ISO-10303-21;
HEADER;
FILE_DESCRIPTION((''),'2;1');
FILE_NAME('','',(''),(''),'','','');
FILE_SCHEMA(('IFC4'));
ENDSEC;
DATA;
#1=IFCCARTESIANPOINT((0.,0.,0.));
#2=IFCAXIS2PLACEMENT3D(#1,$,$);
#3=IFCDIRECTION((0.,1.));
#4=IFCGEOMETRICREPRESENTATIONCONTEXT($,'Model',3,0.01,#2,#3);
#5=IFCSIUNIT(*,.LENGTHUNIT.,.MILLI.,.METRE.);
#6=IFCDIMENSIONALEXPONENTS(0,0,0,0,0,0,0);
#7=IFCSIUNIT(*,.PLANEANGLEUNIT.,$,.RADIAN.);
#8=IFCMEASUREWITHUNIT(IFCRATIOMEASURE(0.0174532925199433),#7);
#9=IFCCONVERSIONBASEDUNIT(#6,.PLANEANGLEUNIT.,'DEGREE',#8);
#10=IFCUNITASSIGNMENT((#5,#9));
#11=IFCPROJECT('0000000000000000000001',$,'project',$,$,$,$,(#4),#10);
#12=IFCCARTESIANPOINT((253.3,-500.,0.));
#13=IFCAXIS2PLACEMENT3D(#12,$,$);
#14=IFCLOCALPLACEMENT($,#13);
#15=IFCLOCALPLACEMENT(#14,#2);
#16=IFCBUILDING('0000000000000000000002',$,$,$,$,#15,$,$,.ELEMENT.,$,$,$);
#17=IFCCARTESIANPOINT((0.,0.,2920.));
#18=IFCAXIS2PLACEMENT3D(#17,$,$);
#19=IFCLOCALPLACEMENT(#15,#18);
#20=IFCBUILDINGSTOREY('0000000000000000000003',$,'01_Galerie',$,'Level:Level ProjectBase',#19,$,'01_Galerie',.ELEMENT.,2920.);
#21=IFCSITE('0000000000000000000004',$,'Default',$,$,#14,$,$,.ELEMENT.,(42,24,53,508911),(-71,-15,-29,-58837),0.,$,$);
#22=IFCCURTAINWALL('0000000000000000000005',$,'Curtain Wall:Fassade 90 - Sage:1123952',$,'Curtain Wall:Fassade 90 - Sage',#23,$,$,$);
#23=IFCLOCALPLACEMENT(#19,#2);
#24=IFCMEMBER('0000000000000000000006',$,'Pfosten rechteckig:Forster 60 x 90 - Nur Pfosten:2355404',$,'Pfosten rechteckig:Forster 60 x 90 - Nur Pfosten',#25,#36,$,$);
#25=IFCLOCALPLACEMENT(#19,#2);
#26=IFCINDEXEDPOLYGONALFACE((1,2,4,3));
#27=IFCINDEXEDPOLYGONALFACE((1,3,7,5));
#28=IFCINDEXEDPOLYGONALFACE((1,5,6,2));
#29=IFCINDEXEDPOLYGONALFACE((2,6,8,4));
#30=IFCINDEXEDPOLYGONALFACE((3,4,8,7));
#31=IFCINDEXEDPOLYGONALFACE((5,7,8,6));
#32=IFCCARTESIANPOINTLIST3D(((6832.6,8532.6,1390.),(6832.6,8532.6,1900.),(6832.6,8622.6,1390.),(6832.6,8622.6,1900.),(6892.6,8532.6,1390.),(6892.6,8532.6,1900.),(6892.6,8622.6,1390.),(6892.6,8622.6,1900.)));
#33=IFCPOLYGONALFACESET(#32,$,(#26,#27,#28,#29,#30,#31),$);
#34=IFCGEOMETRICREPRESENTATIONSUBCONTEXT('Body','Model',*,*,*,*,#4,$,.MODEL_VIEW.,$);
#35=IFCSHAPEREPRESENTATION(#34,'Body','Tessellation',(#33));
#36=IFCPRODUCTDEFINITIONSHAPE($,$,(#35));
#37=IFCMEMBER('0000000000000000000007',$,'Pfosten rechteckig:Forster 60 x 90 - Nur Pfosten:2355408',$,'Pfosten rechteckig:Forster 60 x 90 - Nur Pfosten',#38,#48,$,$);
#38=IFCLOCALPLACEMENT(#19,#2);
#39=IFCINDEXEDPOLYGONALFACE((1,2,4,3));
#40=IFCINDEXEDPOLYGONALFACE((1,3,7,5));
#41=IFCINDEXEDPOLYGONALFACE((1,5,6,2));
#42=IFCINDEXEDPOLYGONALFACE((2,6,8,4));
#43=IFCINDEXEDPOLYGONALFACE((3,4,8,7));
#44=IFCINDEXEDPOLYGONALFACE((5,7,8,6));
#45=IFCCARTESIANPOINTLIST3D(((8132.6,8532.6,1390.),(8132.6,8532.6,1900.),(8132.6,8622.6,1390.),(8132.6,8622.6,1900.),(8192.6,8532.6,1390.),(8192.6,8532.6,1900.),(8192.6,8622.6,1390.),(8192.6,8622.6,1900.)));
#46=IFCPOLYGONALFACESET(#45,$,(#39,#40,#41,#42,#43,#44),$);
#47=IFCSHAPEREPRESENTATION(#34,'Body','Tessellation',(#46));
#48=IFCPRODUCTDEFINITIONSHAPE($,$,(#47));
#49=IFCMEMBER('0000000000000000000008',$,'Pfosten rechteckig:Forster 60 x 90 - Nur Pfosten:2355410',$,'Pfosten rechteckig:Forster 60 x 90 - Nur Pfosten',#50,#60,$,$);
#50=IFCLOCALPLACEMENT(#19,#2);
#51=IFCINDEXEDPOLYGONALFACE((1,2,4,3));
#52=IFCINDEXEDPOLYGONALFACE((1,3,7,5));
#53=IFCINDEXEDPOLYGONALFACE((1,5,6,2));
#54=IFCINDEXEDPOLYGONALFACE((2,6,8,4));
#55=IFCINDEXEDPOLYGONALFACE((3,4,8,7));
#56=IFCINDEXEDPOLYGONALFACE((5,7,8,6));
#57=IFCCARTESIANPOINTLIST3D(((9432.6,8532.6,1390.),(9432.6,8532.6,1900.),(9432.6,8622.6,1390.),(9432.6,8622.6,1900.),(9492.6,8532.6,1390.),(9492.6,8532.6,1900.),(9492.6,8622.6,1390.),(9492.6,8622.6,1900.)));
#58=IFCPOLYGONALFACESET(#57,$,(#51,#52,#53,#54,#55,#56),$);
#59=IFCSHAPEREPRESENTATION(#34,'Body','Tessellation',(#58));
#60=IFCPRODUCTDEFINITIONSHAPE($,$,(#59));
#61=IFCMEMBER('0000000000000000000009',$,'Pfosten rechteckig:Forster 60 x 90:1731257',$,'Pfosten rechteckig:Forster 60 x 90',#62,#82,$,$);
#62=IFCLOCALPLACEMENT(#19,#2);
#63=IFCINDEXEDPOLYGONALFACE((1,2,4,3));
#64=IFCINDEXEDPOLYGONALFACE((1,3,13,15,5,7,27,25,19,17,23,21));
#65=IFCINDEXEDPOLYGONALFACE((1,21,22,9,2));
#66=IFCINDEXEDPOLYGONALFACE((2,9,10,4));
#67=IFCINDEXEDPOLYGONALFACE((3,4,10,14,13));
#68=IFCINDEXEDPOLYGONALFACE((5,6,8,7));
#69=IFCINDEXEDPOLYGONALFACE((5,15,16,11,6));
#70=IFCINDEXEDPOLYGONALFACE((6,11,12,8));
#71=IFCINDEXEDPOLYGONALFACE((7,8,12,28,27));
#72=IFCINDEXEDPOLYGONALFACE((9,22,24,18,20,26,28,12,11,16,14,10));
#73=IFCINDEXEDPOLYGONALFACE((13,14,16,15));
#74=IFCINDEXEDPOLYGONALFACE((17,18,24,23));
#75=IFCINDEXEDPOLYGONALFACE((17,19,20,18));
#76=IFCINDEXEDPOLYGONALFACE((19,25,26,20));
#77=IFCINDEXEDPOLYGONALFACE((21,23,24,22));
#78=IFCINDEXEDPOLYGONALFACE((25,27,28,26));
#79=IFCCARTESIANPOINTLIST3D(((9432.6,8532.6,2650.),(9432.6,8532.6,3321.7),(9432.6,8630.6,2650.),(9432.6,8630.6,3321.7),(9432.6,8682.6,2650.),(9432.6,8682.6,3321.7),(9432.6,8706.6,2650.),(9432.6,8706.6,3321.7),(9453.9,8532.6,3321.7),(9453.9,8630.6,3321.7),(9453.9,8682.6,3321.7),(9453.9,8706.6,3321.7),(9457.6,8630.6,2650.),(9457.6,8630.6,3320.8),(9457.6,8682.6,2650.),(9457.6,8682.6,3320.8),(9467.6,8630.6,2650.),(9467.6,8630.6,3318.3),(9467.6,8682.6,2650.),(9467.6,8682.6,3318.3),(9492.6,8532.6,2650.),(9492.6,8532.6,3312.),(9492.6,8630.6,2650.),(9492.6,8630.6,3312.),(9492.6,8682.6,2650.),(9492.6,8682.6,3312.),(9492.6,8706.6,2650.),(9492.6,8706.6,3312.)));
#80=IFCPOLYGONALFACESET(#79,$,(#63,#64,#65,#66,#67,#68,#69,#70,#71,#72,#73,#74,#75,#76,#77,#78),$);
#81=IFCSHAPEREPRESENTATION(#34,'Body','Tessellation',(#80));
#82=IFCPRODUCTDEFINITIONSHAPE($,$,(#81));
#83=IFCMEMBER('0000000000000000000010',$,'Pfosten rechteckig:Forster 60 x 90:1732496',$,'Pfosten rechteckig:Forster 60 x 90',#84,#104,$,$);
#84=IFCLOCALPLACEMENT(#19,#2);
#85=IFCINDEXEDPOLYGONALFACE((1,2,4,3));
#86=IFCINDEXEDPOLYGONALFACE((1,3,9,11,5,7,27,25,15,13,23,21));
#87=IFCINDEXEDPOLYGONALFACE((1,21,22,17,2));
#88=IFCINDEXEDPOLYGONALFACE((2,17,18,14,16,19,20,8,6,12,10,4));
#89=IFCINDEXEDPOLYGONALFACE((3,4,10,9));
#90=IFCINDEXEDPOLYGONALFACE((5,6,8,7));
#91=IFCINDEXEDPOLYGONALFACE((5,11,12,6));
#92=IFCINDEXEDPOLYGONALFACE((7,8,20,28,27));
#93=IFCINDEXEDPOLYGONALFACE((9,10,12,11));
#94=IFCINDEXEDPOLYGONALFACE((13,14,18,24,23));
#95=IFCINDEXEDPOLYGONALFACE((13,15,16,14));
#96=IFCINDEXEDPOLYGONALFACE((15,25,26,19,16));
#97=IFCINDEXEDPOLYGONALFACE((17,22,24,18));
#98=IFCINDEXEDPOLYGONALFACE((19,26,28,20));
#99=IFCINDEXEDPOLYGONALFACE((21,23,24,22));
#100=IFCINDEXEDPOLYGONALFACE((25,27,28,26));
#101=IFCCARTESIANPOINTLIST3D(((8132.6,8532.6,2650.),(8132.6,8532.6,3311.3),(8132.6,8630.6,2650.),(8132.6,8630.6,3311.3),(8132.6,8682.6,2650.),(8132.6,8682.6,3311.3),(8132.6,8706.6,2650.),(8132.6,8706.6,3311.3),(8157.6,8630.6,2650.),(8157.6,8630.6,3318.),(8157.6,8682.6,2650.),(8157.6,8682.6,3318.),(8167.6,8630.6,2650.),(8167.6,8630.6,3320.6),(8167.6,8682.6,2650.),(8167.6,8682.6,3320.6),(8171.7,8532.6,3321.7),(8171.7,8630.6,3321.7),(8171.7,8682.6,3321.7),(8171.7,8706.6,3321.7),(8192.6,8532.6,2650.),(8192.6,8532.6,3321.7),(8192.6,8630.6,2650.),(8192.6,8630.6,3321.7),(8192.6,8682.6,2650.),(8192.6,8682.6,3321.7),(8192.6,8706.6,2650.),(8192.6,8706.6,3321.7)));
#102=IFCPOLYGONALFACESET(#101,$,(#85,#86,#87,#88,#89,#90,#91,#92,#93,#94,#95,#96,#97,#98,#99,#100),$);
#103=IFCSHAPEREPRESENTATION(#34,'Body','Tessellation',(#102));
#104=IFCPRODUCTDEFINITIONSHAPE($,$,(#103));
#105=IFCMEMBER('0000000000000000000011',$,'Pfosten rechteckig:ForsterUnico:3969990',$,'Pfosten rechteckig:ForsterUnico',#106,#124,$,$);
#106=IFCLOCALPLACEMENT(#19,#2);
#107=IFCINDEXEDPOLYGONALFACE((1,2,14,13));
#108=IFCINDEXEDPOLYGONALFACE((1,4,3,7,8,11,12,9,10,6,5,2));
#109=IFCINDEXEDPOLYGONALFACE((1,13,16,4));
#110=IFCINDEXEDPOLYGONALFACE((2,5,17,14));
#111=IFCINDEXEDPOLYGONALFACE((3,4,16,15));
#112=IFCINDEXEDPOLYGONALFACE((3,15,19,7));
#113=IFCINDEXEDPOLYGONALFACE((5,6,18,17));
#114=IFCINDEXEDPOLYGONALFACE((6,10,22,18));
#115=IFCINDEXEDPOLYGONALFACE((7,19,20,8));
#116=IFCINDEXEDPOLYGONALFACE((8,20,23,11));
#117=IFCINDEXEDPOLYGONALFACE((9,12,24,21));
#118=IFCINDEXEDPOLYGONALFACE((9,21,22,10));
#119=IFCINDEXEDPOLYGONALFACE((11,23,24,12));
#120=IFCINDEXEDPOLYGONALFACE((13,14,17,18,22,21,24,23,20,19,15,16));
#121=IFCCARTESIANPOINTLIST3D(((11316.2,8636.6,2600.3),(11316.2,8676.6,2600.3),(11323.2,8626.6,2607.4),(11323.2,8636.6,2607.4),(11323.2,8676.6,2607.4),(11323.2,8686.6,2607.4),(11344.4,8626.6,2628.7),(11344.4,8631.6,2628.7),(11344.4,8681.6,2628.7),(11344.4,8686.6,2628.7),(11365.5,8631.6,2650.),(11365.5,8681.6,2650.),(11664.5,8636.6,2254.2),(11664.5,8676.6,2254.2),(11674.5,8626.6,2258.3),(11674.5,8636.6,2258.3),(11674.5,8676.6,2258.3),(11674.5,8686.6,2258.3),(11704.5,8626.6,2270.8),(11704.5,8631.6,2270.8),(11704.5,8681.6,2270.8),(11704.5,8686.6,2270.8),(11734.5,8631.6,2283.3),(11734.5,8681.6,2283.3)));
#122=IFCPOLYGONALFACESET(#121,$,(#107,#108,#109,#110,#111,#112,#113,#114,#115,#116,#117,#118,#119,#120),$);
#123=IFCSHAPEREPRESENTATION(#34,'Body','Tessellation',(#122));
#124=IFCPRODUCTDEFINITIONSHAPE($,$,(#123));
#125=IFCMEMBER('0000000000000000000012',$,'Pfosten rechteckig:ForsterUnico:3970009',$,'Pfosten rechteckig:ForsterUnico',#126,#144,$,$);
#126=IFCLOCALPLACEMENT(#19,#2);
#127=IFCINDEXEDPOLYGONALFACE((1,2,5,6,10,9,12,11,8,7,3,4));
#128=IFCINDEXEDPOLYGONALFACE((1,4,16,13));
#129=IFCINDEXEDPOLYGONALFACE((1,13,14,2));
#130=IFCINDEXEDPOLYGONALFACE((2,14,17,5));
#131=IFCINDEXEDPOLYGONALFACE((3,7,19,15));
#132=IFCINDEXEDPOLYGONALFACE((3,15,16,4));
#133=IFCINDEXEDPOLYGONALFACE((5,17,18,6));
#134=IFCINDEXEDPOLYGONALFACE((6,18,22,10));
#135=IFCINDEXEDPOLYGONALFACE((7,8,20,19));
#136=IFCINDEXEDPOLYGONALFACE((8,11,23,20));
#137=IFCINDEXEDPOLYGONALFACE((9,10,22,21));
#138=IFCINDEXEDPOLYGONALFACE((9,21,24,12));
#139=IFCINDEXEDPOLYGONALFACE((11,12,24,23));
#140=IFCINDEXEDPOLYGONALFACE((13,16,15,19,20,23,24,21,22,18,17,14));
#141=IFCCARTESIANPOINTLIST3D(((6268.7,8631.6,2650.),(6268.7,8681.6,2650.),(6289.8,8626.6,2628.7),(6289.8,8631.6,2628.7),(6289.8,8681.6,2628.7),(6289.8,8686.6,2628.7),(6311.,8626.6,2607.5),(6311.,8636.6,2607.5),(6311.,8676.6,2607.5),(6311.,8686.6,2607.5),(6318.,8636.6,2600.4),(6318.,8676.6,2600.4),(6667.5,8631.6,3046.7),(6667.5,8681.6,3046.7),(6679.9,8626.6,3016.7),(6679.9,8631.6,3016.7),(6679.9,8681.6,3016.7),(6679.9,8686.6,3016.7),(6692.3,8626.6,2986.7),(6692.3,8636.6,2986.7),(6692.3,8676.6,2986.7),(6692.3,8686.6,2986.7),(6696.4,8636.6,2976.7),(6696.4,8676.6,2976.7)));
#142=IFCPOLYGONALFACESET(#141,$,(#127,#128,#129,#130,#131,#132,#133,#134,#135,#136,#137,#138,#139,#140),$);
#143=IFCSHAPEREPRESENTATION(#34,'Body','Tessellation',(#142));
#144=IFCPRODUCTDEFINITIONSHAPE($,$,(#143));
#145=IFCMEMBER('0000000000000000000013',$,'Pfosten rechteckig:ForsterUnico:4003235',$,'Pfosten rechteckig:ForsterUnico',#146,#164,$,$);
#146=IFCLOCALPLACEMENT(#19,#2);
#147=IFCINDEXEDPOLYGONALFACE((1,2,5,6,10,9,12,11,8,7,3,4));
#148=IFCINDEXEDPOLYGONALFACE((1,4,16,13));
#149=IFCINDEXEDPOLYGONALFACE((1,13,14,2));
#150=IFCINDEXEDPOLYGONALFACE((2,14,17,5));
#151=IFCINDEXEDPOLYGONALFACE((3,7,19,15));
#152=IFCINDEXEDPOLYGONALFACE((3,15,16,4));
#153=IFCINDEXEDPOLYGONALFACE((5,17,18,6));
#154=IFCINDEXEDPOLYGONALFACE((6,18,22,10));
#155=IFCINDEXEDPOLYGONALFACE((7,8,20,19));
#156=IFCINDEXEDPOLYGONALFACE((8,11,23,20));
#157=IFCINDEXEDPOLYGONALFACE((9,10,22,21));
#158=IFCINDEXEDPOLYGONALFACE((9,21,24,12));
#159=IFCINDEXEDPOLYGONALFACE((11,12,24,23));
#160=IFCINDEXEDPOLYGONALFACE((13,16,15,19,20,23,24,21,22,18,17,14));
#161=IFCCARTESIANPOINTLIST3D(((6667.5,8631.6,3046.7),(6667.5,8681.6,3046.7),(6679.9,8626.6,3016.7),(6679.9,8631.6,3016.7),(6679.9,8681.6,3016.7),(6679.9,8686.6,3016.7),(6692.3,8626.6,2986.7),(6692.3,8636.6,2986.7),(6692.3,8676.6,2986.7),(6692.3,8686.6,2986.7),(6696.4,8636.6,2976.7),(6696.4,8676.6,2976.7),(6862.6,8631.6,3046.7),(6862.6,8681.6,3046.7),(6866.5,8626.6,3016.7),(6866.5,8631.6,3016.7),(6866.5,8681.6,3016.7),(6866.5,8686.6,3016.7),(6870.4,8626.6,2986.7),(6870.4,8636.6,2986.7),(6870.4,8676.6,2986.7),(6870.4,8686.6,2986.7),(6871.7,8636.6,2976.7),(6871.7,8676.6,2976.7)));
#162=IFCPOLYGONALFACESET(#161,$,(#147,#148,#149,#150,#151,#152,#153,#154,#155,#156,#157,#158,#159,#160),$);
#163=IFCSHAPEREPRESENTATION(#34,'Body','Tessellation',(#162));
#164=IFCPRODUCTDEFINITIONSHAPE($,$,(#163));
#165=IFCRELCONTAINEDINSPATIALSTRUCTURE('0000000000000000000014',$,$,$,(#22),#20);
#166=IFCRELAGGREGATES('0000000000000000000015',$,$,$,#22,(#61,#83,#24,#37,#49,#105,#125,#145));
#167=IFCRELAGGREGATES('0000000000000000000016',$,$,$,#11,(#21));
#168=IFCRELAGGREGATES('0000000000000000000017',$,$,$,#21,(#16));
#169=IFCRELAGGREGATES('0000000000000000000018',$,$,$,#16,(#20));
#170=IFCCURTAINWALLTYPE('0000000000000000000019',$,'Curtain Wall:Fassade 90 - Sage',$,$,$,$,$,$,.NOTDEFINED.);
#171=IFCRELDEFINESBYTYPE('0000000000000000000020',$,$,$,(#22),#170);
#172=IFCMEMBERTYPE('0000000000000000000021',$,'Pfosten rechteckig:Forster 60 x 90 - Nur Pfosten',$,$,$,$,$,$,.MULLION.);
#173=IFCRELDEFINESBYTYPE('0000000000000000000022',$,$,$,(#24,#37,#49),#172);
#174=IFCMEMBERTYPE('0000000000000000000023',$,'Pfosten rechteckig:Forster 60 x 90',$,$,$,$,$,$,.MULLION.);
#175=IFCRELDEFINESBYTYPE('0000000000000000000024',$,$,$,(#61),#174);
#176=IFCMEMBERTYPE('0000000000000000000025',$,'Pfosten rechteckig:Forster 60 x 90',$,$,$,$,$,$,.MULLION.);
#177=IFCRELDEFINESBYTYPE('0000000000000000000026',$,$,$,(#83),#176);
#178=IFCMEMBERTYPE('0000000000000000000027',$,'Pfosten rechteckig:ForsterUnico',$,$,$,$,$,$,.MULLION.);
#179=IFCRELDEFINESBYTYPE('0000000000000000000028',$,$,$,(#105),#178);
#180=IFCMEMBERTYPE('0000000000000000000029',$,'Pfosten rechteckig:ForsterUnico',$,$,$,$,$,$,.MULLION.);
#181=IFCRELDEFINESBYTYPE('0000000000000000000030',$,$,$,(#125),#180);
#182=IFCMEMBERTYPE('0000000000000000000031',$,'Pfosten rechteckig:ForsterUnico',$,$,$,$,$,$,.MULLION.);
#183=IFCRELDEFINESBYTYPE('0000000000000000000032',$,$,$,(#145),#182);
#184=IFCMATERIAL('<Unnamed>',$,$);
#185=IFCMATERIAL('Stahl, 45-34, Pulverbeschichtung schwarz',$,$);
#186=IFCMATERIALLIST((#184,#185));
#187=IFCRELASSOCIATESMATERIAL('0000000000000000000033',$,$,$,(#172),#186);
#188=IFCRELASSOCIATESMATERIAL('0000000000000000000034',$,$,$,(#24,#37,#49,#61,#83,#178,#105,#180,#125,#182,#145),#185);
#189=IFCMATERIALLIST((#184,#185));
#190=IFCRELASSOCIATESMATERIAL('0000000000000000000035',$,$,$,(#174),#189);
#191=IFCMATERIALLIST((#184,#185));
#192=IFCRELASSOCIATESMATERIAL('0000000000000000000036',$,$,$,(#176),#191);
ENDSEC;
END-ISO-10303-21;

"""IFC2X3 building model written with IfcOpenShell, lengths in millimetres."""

from ifc_helpers import new_model, entity, si_unit, converted_unit, direction, frame, origin, origin_2d_with_axis, place, context, subcontext, project, spatial, polyline, rectangle, outline, extrude, clip, halfspace, source, transform, mapped, material, material_list, type_object, type_shapes, element, aggregate, save


model = new_model("IFC2X3")

# Units and contexts
model_context = context("Model", 3, precision=0.01, world=origin(), true_north=direction((0.0, 1.0)))
body_context = subcontext(model_context, "Body", "Model", "MODEL_VIEW")
ifc_project = project(units=[si_unit("LENGTHUNIT", "METRE", prefix="MILLI"), converted_unit("PLANEANGLEUNIT", "DEGREE", entity("IfcRatioMeasure", 0.0174532925199433), si_unit("PLANEANGLEUNIT", "RADIAN"), dimensions=[0, 0, 0, 0, 0, 0, 0])], contexts=[model_context])

# Site, building, storey
site_placement = place(None, frame((253.3, -500.0, 0.0)))
site = spatial("IfcSite", under=ifc_project, at=site_placement, Name="Default", CompositionType="ELEMENT", RefLatitude=(42, 24, 53, 508911), RefLongitude=(-71, -15, -29, -58837), RefElevation=0.0)
building_placement = place(site_placement, origin())
building = spatial("IfcBuilding", under=site, at=building_placement, CompositionType="ELEMENT")
storey_placement = place(building_placement, frame((0.0, 0.0, 2920.0)))
storey = spatial("IfcBuildingStorey", under=building, at=storey_placement, Name="01_Galerie", ObjectType="Level:Level ProjectBase", LongName="01_Galerie", CompositionType="ELEMENT", Elevation=2920.0)

# Curtain wall, members
curtain_wall_type = type_object("IfcCurtainWallType", Name="Curtain Wall:Fassade 90 - Sage", PredefinedType="NOTDEFINED")
curtain_wall_1_placement = place(storey_placement, frame((0.0, 0.0, -2920.0)))
curtain_wall_1 = element("IfcCurtainWall", 1, at=curtain_wall_1_placement, inside=storey, type_object=curtain_wall_type, Name="Curtain Wall:Fassade 90 - Sage:1123952", ObjectType="Curtain Wall:Fassade 90 - Sage")
ifc_material_1 = material(Name="Stahl, 45-34, Pulverbeschichtung schwarz")
ifc_material_2 = material(Name="<Unnamed>")
ifc_material_list_1 = material_list([ifc_material_2, ifc_material_1])
member_type_1 = type_object("IfcMemberType", Name="Pfosten rechteckig:Forster 60 x 90 - Nur Pfosten", PredefinedType="MULLION", material=ifc_material_list_1)
shared_shape_1 = source(origin(), body_context, "Body", "SweptSolid", [
    extrude(rectangle(XDim=90.0, YDim=60.0, at=origin_2d_with_axis()), frame((0.0, 79.0, -510.0), z_axis=(0.0, 0.0, 1.0), x_axis=(0.0, -1.0, 0.0)), (0.0, 0.0, 1.0), 510.0),
])
type_shapes(member_type_1, [shared_shape_1])
member_1_placement = place(storey_placement, frame((6862.6, 8656.6, 1390.0), z_axis=(0.0, 0.0, -1.0), x_axis=(1.0, 0.0, 0.0)))
member_1 = element("IfcMember", 2, at=member_1_placement, type_object=member_type_1, material=ifc_material_1, Name="Pfosten rechteckig:Forster 60 x 90 - Nur Pfosten:2355404", ObjectType="Pfosten rechteckig:Forster 60 x 90 - Nur Pfosten", context=body_context, shape_type="MappedRepresentation", body=[
    mapped(shared_shape_1, transform((0.0, 0.0, 0.0), scale=1.0)),
])
member_2_placement = place(storey_placement, frame((8162.6, 8656.6, 1390.0), z_axis=(0.0, 0.0, -1.0), x_axis=(1.0, 0.0, 0.0)))
member_2 = element("IfcMember", 3, at=member_2_placement, type_object=member_type_1, material=ifc_material_1, Name="Pfosten rechteckig:Forster 60 x 90 - Nur Pfosten:2355408", ObjectType="Pfosten rechteckig:Forster 60 x 90 - Nur Pfosten", context=body_context, shape_type="MappedRepresentation", body=[
    mapped(shared_shape_1, transform((0.0, 0.0, 0.0), scale=1.0)),
])
member_3_placement = place(storey_placement, frame((9462.6, 8656.6, 1390.0), z_axis=(0.0, 0.0, -1.0), x_axis=(1.0, 0.0, 0.0)))
member_3 = element("IfcMember", 4, at=member_3_placement, type_object=member_type_1, material=ifc_material_1, Name="Pfosten rechteckig:Forster 60 x 90 - Nur Pfosten:2355410", ObjectType="Pfosten rechteckig:Forster 60 x 90 - Nur Pfosten", context=body_context, shape_type="MappedRepresentation", body=[
    mapped(shared_shape_1, transform((0.0, 0.0, 0.0), scale=1.0)),
])
ifc_material_list_2 = material_list([ifc_material_2, ifc_material_1])
member_type_2 = type_object("IfcMemberType", Name="Pfosten rechteckig:Forster 60 x 90", PredefinedType="MULLION", material=ifc_material_list_2)
shared_shape_2 = source(origin(), body_context, "Body", "Clipping", [
    clip(extrude(outline(polyline([(-111.7, -30.0), (-13.7, -30.0), (-13.7, -5.0), (38.3, -5.0), (38.3, -30.0), (62.3, -30.0), (62.3, 30.0), (38.3, 30.0), (38.3, 5.0), (-13.7, 5.0), (-13.7, 30.0), (-111.7, 30.0), (-111.7, -30.0)])), frame((0.0, 12.3, -671.7), z_axis=(0.0, 0.0, 1.0), x_axis=(0.0, -1.0, 0.0)), (0.0, 0.0, 1.0), 671.7), halfspace(frame((1282.9, 91440.0, -347.1), z_axis=(0.243738, 0.0, -0.969841), x_axis=(-0.969841, 0.0, -0.243738)), False)),
])
type_shapes(member_type_2, [shared_shape_2])
member_4_placement = place(storey_placement, frame((9462.6, 8656.6, 2650.0), z_axis=(0.0, 0.0, -1.0), x_axis=(1.0, 0.0, 0.0)))
member_4 = element("IfcMember", 5, at=member_4_placement, type_object=member_type_2, material=ifc_material_1, Name="Pfosten rechteckig:Forster 60 x 90:1731257", ObjectType="Pfosten rechteckig:Forster 60 x 90", context=body_context, shape_type="MappedRepresentation", body=[
    mapped(shared_shape_2, transform((0.0, 0.0, 0.0), scale=1.0)),
])
ifc_material_list_3 = material_list([ifc_material_2, ifc_material_1])
member_type_3 = type_object("IfcMemberType", Name="Pfosten rechteckig:Forster 60 x 90", PredefinedType="MULLION", material=ifc_material_list_3)
shared_shape_3 = source(origin(), body_context, "Body", "Clipping", [
    clip(extrude(outline(polyline([(-111.7, -30.0), (-13.7, -30.0), (-13.7, -5.0), (38.3, -5.0), (38.3, -30.0), (62.3, -30.0), (62.3, 30.0), (38.3, 30.0), (38.3, 5.0), (-13.7, 5.0), (-13.7, 30.0), (-111.7, 30.0), (-111.7, -30.0)])), frame((0.0, 12.3, -671.7), z_axis=(0.0, 0.0, 1.0), x_axis=(0.0, -1.0, 0.0)), (0.0, 0.0, 1.0), 671.7), halfspace(frame((9.1, 91440.0, -671.7), z_axis=(-0.256506, 0.0, -0.966543), x_axis=(-0.966543, 0.0, 0.256506)), False)),
])
type_shapes(member_type_3, [shared_shape_3])
member_5_placement = place(storey_placement, frame((8162.6, 8656.6, 2650.0), z_axis=(0.0, 0.0, -1.0), x_axis=(1.0, 0.0, 0.0)))
member_5 = element("IfcMember", 6, at=member_5_placement, type_object=member_type_3, material=ifc_material_1, Name="Pfosten rechteckig:Forster 60 x 90:1732496", ObjectType="Pfosten rechteckig:Forster 60 x 90", context=body_context, shape_type="MappedRepresentation", body=[
    mapped(shared_shape_3, transform((0.0, 0.0, 0.0), scale=1.0)),
])
member_type_4 = type_object("IfcMemberType", Name="Pfosten rechteckig:ForsterUnico", PredefinedType="MULLION", material=ifc_material_1)
shared_shape_4 = source(origin(), body_context, "Body", "Clipping", [
    clip(extrude(outline(polyline([(-20.0, -28.3), (20.0, -28.3), (20.0, -18.3), (30.0, -18.3), (30.0, 11.7), (25.0, 11.7), (25.0, 41.7), (-25.0, 41.7), (-25.0, 11.7), (-30.0, 11.7), (-30.0, -18.3), (-20.0, -18.3), (-20.0, -28.3)])), frame((-41.7, 0.0, -520.2), z_axis=(0.0, 0.0, 1.0), x_axis=(0.0, -1.0, 0.0)), (0.0, 0.0, 1.0), 520.2), halfspace(frame((0.0, -304.8, 0.0), z_axis=(-0.384128, 0.0, 0.92328), x_axis=(-0.92328, 0.0, -0.384128)), False)),
])
type_shapes(member_type_4, [shared_shape_4])
member_6_placement = place(storey_placement, frame((11734.5, 8656.6, 2283.3), z_axis=(0.709315, 0.0, -0.704892), x_axis=(0.704892, 0.0, 0.709315)))
member_6 = element("IfcMember", 7, at=member_6_placement, type_object=member_type_4, material=ifc_material_1, Name="Pfosten rechteckig:ForsterUnico:3969990", ObjectType="Pfosten rechteckig:ForsterUnico", context=body_context, shape_type="MappedRepresentation", body=[
    mapped(shared_shape_4, transform((0.0, 0.0, 0.0), scale=1.0)),
])
member_type_5 = type_object("IfcMemberType", Name="Pfosten rechteckig:ForsterUnico", PredefinedType="MULLION", material=ifc_material_1)
shared_shape_5 = source(origin(), body_context, "Body", "Clipping", [
    clip(extrude(outline(polyline([(-20.0, -28.3), (20.0, -28.3), (20.0, -18.3), (30.0, -18.3), (30.0, 11.7), (25.0, 11.7), (25.0, 41.7), (-25.0, 41.7), (-25.0, 11.7), (-30.0, 11.7), (-30.0, -18.3), (-20.0, -18.3), (-20.0, -28.3)])), frame((-41.7, 0.0, -562.5), z_axis=(0.0, 0.0, 1.0), x_axis=(0.0, -1.0, 0.0)), (0.0, 0.0, 1.0), 562.5), halfspace(frame((0.0, -304.8, 0.0), z_axis=(-0.381439, 0.0, 0.924394), x_axis=(-0.924394, 0.0, -0.381439)), False)),
])
type_shapes(member_type_5, [shared_shape_5])
member_7_placement = place(storey_placement, frame((6667.5, 8656.6, 3046.7), z_axis=(0.709009, 0.0, 0.7052), x_axis=(-0.7052, 0.0, 0.709009)))
member_7 = element("IfcMember", 8, at=member_7_placement, type_object=member_type_5, material=ifc_material_1, Name="Pfosten rechteckig:ForsterUnico:3970009", ObjectType="Pfosten rechteckig:ForsterUnico", context=body_context, shape_type="MappedRepresentation", body=[
    mapped(shared_shape_5, transform((0.0, 0.0, 0.0), scale=1.0)),
])
member_type_6 = type_object("IfcMemberType", Name="Pfosten rechteckig:ForsterUnico", PredefinedType="MULLION", material=ifc_material_1)
shared_shape_6 = source(origin(), body_context, "Body", "Clipping", [
    clip(clip(extrude(outline(polyline([(-20.0, -28.3), (20.0, -28.3), (20.0, -18.3), (30.0, -18.3), (30.0, 11.7), (25.0, 11.7), (25.0, 41.7), (-25.0, 41.7), (-25.0, 11.7), (-30.0, 11.7), (-30.0, -18.3), (-20.0, -18.3), (-20.0, -28.3)])), frame((-41.7, 0.0, -195.1), z_axis=(0.0, 0.0, 1.0), x_axis=(0.0, -1.0, 0.0)), (0.0, 0.0, 1.0), 204.2), halfspace(frame((0.0, -304.8, -195.1), z_axis=(-0.381439, 0.0, -0.924394), x_axis=(-0.924394, 0.0, 0.381439)), False)), halfspace(frame((0.0, 304.8, 0.0), z_axis=(0.129339, 0.0, 0.9916), x_axis=(0.9916, 0.0, -0.129339)), False)),
])
type_shapes(member_type_6, [shared_shape_6])
member_8_placement = place(storey_placement, frame((6862.6, 8656.6, 3046.7), z_axis=(1.0, 0.0, 0.0), x_axis=(0.0, 0.0, 1.0)))
member_8 = element("IfcMember", 9, at=member_8_placement, type_object=member_type_6, material=ifc_material_1, Name="Pfosten rechteckig:ForsterUnico:4003235", ObjectType="Pfosten rechteckig:ForsterUnico", context=body_context, shape_type="MappedRepresentation", body=[
    mapped(shared_shape_6, transform((0.0, 0.0, 0.0), scale=1.0)),
])

aggregate(curtain_wall_1, [member_4, member_5, member_1, member_2, member_3, member_6, member_7, member_8])

save(model, "model.ifc")
